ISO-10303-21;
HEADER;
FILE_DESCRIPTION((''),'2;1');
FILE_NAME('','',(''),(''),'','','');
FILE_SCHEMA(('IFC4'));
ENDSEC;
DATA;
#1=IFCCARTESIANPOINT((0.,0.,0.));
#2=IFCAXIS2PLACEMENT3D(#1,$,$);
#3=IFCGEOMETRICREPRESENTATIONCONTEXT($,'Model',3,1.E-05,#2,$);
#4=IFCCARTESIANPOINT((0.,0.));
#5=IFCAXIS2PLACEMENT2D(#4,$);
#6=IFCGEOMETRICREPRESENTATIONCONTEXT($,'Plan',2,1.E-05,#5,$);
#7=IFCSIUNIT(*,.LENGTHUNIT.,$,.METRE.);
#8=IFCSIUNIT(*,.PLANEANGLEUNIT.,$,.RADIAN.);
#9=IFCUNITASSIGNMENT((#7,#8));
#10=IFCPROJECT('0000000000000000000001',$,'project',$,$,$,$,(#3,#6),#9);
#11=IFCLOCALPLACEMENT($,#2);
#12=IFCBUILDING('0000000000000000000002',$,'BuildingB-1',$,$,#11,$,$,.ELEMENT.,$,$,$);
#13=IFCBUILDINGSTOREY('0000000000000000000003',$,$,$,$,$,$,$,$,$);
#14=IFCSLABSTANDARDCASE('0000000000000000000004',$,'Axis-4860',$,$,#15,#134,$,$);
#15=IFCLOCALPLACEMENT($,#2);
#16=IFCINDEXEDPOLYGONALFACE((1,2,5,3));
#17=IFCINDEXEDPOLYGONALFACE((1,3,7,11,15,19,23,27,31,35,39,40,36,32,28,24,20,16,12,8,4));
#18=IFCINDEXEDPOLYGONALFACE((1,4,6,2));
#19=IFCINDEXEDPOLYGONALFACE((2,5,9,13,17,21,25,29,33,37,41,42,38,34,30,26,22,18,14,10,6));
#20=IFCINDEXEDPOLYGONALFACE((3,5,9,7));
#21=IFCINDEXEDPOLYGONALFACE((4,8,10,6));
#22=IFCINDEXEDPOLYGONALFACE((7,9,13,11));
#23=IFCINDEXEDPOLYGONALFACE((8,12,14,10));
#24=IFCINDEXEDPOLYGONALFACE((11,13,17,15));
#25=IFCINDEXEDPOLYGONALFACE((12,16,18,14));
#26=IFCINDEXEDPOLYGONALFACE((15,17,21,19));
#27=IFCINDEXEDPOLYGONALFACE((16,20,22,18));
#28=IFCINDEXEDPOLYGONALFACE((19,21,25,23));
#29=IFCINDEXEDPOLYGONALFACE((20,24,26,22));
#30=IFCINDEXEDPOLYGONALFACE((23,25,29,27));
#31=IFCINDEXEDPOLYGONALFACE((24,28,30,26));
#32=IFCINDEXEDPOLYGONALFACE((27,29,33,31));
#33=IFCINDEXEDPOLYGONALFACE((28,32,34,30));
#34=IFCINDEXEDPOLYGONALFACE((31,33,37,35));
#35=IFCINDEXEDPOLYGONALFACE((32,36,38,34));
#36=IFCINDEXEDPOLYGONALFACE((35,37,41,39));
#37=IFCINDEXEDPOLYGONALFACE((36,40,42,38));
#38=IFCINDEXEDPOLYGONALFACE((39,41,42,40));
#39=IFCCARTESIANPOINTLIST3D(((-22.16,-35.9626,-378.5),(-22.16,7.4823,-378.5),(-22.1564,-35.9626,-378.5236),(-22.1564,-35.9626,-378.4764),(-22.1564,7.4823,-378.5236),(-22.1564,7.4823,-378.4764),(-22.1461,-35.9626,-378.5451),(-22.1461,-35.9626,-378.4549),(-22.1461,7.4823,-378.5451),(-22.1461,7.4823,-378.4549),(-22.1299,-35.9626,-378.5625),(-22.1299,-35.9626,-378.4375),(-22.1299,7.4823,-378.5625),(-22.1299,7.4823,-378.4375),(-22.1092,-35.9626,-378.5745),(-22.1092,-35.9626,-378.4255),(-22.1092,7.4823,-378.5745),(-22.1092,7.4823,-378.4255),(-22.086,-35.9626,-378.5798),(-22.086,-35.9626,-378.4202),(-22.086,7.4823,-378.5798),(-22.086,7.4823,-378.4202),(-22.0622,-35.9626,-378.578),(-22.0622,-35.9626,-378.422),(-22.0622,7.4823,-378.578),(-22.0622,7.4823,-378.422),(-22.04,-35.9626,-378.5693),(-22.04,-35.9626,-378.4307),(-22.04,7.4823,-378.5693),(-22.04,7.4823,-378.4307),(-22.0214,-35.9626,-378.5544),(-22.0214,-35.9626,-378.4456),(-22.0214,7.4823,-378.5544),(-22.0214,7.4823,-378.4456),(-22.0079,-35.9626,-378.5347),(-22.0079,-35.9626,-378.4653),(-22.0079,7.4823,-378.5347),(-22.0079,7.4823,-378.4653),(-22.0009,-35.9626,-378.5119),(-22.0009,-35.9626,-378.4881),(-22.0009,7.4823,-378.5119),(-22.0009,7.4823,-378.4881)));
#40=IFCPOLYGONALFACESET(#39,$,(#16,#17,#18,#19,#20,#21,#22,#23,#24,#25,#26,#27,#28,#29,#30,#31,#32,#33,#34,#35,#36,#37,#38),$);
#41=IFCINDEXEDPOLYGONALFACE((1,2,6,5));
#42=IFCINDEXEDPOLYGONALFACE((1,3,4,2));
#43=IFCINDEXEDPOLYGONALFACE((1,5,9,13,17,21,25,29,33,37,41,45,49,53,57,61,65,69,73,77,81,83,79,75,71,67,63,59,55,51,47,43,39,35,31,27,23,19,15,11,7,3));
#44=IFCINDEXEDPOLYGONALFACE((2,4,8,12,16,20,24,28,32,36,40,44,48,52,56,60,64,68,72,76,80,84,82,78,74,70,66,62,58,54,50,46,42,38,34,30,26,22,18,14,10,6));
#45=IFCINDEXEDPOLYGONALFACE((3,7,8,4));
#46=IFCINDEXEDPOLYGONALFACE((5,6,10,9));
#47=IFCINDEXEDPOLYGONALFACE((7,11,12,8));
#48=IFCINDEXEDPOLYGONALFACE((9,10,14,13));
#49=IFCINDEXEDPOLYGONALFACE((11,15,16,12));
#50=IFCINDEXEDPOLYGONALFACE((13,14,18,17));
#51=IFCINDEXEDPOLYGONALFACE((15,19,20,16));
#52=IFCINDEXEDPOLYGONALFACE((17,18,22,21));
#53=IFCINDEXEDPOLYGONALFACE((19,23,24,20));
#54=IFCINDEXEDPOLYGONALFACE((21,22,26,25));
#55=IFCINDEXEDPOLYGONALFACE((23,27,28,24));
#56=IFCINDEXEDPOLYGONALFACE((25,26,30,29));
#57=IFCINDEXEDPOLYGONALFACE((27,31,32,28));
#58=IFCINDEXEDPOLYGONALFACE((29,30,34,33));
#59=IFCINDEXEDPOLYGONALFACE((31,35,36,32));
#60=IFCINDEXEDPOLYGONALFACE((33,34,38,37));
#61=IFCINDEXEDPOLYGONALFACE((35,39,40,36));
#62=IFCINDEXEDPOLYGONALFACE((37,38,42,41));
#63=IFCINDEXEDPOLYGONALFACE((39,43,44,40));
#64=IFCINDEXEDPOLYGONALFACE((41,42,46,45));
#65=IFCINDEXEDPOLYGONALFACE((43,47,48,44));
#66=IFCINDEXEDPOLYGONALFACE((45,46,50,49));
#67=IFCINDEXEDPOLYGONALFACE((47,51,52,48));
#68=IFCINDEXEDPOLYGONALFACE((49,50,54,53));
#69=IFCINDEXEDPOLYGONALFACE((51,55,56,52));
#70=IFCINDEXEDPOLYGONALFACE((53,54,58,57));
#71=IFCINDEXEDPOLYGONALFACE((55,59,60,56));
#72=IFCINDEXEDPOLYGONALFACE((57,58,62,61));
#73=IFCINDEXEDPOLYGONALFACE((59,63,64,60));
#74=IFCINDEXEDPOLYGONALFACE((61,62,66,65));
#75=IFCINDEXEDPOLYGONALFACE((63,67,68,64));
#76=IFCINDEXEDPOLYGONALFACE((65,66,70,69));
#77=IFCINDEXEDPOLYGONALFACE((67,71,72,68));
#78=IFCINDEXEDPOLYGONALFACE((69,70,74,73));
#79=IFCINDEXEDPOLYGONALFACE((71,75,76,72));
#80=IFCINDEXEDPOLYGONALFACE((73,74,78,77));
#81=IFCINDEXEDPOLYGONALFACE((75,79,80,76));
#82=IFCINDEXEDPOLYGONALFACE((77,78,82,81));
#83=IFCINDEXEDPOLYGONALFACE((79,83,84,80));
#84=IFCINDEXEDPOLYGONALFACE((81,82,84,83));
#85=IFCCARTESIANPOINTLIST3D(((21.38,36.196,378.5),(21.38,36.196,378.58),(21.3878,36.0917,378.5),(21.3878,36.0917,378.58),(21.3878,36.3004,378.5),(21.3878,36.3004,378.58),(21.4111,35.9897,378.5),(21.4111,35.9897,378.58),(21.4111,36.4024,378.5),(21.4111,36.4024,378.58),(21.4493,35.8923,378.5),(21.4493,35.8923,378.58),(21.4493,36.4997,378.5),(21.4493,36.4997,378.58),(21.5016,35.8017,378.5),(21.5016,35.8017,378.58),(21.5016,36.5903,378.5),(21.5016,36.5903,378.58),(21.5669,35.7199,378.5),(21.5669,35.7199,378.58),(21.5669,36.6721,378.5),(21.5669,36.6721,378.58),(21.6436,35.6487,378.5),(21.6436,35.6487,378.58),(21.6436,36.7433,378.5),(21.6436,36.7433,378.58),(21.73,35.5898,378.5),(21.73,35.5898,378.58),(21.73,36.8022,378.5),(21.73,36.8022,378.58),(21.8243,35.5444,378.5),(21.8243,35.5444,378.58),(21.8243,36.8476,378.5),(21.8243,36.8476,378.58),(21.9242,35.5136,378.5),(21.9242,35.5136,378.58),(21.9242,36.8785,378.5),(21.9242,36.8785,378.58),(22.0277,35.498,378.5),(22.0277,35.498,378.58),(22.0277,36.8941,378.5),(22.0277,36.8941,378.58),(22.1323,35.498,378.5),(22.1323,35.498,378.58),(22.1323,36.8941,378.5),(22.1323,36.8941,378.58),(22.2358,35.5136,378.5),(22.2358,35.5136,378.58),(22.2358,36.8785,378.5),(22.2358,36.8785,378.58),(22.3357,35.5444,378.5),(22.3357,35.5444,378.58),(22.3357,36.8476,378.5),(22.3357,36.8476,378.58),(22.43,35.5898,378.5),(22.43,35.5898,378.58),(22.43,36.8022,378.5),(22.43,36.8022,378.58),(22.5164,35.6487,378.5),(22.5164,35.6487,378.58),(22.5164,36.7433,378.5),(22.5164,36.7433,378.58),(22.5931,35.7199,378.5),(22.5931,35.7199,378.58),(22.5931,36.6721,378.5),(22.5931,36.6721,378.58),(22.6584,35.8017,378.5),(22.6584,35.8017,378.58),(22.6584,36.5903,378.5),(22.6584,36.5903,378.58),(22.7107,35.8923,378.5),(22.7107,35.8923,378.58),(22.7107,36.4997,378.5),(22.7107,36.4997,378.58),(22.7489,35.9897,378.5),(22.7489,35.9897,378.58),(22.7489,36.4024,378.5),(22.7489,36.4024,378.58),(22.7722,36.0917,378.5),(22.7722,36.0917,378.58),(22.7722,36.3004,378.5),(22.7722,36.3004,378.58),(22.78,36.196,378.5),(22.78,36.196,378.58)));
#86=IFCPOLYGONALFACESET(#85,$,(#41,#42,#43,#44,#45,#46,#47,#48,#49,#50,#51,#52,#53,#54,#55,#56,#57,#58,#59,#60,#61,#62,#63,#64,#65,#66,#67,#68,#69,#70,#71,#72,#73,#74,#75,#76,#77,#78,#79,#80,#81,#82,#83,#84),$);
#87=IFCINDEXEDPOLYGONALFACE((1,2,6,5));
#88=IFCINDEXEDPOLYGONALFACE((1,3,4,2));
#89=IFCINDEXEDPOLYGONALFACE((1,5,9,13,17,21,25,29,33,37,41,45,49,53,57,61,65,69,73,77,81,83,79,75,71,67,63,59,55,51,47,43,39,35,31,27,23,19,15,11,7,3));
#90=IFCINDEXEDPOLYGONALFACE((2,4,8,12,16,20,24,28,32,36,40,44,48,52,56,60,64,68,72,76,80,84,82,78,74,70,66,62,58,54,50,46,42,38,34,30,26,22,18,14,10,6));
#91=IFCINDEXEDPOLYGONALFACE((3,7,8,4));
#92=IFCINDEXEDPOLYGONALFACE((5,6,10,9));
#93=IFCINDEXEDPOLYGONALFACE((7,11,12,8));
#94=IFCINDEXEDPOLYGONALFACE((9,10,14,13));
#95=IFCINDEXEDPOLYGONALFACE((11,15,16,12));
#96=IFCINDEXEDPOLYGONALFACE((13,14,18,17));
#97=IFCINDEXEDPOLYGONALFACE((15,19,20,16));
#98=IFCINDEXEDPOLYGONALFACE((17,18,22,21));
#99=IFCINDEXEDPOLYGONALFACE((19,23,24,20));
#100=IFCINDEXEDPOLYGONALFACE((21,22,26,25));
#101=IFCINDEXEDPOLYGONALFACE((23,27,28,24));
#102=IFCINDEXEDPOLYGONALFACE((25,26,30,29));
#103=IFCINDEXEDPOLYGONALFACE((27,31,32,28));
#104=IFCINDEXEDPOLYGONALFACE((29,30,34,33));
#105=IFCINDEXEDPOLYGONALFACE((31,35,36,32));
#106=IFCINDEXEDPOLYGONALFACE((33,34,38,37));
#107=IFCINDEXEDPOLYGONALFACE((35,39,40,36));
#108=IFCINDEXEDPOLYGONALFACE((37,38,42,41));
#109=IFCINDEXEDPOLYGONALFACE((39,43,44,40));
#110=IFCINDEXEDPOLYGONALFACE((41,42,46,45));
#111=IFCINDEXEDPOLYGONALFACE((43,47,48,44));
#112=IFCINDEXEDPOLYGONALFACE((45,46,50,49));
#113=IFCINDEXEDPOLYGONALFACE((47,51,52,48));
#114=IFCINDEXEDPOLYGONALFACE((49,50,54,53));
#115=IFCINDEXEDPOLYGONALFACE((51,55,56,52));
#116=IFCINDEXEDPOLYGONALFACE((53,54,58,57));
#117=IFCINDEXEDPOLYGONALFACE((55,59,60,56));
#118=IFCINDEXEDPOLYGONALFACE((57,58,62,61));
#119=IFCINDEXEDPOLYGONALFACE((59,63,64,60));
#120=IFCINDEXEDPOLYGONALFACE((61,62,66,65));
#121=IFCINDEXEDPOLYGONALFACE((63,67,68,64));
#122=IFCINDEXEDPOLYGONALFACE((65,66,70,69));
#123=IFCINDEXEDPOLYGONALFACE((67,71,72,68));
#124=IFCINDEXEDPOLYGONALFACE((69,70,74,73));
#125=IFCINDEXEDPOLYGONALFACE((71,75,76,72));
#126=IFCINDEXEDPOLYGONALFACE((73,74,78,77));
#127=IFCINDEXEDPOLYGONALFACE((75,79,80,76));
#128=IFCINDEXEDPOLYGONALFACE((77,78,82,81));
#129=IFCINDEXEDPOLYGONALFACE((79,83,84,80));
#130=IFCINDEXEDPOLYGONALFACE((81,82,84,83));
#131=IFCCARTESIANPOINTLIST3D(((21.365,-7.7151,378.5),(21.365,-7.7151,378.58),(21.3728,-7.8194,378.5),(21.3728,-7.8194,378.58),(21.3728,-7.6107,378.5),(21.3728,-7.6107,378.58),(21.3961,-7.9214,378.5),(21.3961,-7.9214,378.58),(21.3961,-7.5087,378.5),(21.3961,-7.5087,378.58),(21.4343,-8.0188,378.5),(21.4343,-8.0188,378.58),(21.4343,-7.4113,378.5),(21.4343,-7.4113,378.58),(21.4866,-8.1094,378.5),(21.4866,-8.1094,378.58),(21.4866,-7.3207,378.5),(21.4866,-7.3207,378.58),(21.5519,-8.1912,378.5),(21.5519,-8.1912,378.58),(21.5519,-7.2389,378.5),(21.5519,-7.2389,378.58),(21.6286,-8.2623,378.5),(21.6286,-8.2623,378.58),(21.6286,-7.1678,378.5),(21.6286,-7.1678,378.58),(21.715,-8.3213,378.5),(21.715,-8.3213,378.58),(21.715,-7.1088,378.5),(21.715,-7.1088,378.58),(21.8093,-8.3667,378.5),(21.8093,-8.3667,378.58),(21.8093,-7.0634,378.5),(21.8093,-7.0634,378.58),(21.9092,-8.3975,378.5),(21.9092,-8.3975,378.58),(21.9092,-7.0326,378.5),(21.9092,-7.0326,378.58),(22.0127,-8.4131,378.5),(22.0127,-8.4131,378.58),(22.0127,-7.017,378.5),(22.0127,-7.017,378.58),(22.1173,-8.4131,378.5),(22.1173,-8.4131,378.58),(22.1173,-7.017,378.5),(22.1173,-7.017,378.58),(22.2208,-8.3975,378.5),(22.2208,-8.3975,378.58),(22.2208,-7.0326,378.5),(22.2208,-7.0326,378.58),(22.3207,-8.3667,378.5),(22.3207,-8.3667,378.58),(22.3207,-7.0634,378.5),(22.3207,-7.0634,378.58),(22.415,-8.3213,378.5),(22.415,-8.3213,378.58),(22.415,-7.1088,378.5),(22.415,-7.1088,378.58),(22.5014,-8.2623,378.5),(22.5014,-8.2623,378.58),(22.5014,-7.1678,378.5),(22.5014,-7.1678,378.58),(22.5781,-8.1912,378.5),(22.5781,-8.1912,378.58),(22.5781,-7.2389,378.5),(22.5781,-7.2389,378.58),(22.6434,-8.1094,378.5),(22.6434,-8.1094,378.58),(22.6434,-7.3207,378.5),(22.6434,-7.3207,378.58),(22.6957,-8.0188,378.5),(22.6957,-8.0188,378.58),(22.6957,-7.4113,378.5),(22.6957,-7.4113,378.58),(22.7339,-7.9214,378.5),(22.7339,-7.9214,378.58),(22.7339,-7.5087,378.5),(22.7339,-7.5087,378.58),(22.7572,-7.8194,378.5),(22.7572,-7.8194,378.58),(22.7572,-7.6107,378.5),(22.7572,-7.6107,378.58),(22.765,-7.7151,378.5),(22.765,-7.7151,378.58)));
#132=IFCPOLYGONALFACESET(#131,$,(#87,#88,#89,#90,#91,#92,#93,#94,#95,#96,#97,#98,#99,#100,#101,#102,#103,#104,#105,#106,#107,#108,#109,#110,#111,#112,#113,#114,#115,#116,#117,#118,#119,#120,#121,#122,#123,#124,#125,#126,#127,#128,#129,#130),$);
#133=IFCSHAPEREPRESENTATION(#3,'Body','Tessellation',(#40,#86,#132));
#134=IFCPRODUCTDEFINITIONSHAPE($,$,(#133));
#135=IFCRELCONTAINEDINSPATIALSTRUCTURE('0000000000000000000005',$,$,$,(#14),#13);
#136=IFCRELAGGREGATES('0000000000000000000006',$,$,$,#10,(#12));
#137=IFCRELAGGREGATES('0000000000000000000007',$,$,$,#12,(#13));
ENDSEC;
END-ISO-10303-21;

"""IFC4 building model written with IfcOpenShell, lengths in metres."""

from ifc_helpers import new_model, entity, si_unit, frame, origin, origin_2d, place, context, project, spatial, circle, extrude, element, save


model = new_model("IFC4")

# Units and contexts
model_context = context("Model", 3, precision=1e-05, world=origin())
plan_context = context("Plan", 2, precision=1e-05, world=origin_2d())
ifc_project = project(units=[si_unit("LENGTHUNIT", "METRE"), si_unit("PLANEANGLEUNIT", "RADIAN")], contexts=[model_context, plan_context])

# Building, storey
building_placement = place(None, origin())
building = spatial("IfcBuilding", under=ifc_project, at=building_placement, Name="BuildingB-1", CompositionType="ELEMENT")
storey = spatial("IfcBuildingStorey", under=building)

# Slab
element("IfcSlabStandardCase", 1, inside=storey, Name="Axis-4860", context=model_context, shape_type="AdvancedSweptSolid", body=[
    entity("IfcSurfaceCurveSweptAreaSolid", entity("IfcCircleProfileDef", "AREA", None, None, 0.08), None, entity("IfcPolyline", [entity("IfcCartesianPoint", [22.08, 35.9626, 378.5]), entity("IfcCartesianPoint", [22.08, -7.4823, 378.5])]), None, None, entity("IfcPlane", entity("IfcAxis2Placement3D", entity("IfcCartesianPoint", [22.08, 35.9626, 378.5]), entity("IfcDirection", [0.0, 0.0, 1.0]), entity("IfcDirection", [1.0, 0.0, 0.0])))),
    extrude(circle(Radius=0.7), frame((22.08, 36.196, 378.5)), (0.0, 0.0, 1.0), 0.08),
    extrude(circle(Radius=0.7), frame((22.065, -7.7151, 378.5)), (0.0, 0.0, 1.0), 0.08),
])

save(model, "model.ifc")
